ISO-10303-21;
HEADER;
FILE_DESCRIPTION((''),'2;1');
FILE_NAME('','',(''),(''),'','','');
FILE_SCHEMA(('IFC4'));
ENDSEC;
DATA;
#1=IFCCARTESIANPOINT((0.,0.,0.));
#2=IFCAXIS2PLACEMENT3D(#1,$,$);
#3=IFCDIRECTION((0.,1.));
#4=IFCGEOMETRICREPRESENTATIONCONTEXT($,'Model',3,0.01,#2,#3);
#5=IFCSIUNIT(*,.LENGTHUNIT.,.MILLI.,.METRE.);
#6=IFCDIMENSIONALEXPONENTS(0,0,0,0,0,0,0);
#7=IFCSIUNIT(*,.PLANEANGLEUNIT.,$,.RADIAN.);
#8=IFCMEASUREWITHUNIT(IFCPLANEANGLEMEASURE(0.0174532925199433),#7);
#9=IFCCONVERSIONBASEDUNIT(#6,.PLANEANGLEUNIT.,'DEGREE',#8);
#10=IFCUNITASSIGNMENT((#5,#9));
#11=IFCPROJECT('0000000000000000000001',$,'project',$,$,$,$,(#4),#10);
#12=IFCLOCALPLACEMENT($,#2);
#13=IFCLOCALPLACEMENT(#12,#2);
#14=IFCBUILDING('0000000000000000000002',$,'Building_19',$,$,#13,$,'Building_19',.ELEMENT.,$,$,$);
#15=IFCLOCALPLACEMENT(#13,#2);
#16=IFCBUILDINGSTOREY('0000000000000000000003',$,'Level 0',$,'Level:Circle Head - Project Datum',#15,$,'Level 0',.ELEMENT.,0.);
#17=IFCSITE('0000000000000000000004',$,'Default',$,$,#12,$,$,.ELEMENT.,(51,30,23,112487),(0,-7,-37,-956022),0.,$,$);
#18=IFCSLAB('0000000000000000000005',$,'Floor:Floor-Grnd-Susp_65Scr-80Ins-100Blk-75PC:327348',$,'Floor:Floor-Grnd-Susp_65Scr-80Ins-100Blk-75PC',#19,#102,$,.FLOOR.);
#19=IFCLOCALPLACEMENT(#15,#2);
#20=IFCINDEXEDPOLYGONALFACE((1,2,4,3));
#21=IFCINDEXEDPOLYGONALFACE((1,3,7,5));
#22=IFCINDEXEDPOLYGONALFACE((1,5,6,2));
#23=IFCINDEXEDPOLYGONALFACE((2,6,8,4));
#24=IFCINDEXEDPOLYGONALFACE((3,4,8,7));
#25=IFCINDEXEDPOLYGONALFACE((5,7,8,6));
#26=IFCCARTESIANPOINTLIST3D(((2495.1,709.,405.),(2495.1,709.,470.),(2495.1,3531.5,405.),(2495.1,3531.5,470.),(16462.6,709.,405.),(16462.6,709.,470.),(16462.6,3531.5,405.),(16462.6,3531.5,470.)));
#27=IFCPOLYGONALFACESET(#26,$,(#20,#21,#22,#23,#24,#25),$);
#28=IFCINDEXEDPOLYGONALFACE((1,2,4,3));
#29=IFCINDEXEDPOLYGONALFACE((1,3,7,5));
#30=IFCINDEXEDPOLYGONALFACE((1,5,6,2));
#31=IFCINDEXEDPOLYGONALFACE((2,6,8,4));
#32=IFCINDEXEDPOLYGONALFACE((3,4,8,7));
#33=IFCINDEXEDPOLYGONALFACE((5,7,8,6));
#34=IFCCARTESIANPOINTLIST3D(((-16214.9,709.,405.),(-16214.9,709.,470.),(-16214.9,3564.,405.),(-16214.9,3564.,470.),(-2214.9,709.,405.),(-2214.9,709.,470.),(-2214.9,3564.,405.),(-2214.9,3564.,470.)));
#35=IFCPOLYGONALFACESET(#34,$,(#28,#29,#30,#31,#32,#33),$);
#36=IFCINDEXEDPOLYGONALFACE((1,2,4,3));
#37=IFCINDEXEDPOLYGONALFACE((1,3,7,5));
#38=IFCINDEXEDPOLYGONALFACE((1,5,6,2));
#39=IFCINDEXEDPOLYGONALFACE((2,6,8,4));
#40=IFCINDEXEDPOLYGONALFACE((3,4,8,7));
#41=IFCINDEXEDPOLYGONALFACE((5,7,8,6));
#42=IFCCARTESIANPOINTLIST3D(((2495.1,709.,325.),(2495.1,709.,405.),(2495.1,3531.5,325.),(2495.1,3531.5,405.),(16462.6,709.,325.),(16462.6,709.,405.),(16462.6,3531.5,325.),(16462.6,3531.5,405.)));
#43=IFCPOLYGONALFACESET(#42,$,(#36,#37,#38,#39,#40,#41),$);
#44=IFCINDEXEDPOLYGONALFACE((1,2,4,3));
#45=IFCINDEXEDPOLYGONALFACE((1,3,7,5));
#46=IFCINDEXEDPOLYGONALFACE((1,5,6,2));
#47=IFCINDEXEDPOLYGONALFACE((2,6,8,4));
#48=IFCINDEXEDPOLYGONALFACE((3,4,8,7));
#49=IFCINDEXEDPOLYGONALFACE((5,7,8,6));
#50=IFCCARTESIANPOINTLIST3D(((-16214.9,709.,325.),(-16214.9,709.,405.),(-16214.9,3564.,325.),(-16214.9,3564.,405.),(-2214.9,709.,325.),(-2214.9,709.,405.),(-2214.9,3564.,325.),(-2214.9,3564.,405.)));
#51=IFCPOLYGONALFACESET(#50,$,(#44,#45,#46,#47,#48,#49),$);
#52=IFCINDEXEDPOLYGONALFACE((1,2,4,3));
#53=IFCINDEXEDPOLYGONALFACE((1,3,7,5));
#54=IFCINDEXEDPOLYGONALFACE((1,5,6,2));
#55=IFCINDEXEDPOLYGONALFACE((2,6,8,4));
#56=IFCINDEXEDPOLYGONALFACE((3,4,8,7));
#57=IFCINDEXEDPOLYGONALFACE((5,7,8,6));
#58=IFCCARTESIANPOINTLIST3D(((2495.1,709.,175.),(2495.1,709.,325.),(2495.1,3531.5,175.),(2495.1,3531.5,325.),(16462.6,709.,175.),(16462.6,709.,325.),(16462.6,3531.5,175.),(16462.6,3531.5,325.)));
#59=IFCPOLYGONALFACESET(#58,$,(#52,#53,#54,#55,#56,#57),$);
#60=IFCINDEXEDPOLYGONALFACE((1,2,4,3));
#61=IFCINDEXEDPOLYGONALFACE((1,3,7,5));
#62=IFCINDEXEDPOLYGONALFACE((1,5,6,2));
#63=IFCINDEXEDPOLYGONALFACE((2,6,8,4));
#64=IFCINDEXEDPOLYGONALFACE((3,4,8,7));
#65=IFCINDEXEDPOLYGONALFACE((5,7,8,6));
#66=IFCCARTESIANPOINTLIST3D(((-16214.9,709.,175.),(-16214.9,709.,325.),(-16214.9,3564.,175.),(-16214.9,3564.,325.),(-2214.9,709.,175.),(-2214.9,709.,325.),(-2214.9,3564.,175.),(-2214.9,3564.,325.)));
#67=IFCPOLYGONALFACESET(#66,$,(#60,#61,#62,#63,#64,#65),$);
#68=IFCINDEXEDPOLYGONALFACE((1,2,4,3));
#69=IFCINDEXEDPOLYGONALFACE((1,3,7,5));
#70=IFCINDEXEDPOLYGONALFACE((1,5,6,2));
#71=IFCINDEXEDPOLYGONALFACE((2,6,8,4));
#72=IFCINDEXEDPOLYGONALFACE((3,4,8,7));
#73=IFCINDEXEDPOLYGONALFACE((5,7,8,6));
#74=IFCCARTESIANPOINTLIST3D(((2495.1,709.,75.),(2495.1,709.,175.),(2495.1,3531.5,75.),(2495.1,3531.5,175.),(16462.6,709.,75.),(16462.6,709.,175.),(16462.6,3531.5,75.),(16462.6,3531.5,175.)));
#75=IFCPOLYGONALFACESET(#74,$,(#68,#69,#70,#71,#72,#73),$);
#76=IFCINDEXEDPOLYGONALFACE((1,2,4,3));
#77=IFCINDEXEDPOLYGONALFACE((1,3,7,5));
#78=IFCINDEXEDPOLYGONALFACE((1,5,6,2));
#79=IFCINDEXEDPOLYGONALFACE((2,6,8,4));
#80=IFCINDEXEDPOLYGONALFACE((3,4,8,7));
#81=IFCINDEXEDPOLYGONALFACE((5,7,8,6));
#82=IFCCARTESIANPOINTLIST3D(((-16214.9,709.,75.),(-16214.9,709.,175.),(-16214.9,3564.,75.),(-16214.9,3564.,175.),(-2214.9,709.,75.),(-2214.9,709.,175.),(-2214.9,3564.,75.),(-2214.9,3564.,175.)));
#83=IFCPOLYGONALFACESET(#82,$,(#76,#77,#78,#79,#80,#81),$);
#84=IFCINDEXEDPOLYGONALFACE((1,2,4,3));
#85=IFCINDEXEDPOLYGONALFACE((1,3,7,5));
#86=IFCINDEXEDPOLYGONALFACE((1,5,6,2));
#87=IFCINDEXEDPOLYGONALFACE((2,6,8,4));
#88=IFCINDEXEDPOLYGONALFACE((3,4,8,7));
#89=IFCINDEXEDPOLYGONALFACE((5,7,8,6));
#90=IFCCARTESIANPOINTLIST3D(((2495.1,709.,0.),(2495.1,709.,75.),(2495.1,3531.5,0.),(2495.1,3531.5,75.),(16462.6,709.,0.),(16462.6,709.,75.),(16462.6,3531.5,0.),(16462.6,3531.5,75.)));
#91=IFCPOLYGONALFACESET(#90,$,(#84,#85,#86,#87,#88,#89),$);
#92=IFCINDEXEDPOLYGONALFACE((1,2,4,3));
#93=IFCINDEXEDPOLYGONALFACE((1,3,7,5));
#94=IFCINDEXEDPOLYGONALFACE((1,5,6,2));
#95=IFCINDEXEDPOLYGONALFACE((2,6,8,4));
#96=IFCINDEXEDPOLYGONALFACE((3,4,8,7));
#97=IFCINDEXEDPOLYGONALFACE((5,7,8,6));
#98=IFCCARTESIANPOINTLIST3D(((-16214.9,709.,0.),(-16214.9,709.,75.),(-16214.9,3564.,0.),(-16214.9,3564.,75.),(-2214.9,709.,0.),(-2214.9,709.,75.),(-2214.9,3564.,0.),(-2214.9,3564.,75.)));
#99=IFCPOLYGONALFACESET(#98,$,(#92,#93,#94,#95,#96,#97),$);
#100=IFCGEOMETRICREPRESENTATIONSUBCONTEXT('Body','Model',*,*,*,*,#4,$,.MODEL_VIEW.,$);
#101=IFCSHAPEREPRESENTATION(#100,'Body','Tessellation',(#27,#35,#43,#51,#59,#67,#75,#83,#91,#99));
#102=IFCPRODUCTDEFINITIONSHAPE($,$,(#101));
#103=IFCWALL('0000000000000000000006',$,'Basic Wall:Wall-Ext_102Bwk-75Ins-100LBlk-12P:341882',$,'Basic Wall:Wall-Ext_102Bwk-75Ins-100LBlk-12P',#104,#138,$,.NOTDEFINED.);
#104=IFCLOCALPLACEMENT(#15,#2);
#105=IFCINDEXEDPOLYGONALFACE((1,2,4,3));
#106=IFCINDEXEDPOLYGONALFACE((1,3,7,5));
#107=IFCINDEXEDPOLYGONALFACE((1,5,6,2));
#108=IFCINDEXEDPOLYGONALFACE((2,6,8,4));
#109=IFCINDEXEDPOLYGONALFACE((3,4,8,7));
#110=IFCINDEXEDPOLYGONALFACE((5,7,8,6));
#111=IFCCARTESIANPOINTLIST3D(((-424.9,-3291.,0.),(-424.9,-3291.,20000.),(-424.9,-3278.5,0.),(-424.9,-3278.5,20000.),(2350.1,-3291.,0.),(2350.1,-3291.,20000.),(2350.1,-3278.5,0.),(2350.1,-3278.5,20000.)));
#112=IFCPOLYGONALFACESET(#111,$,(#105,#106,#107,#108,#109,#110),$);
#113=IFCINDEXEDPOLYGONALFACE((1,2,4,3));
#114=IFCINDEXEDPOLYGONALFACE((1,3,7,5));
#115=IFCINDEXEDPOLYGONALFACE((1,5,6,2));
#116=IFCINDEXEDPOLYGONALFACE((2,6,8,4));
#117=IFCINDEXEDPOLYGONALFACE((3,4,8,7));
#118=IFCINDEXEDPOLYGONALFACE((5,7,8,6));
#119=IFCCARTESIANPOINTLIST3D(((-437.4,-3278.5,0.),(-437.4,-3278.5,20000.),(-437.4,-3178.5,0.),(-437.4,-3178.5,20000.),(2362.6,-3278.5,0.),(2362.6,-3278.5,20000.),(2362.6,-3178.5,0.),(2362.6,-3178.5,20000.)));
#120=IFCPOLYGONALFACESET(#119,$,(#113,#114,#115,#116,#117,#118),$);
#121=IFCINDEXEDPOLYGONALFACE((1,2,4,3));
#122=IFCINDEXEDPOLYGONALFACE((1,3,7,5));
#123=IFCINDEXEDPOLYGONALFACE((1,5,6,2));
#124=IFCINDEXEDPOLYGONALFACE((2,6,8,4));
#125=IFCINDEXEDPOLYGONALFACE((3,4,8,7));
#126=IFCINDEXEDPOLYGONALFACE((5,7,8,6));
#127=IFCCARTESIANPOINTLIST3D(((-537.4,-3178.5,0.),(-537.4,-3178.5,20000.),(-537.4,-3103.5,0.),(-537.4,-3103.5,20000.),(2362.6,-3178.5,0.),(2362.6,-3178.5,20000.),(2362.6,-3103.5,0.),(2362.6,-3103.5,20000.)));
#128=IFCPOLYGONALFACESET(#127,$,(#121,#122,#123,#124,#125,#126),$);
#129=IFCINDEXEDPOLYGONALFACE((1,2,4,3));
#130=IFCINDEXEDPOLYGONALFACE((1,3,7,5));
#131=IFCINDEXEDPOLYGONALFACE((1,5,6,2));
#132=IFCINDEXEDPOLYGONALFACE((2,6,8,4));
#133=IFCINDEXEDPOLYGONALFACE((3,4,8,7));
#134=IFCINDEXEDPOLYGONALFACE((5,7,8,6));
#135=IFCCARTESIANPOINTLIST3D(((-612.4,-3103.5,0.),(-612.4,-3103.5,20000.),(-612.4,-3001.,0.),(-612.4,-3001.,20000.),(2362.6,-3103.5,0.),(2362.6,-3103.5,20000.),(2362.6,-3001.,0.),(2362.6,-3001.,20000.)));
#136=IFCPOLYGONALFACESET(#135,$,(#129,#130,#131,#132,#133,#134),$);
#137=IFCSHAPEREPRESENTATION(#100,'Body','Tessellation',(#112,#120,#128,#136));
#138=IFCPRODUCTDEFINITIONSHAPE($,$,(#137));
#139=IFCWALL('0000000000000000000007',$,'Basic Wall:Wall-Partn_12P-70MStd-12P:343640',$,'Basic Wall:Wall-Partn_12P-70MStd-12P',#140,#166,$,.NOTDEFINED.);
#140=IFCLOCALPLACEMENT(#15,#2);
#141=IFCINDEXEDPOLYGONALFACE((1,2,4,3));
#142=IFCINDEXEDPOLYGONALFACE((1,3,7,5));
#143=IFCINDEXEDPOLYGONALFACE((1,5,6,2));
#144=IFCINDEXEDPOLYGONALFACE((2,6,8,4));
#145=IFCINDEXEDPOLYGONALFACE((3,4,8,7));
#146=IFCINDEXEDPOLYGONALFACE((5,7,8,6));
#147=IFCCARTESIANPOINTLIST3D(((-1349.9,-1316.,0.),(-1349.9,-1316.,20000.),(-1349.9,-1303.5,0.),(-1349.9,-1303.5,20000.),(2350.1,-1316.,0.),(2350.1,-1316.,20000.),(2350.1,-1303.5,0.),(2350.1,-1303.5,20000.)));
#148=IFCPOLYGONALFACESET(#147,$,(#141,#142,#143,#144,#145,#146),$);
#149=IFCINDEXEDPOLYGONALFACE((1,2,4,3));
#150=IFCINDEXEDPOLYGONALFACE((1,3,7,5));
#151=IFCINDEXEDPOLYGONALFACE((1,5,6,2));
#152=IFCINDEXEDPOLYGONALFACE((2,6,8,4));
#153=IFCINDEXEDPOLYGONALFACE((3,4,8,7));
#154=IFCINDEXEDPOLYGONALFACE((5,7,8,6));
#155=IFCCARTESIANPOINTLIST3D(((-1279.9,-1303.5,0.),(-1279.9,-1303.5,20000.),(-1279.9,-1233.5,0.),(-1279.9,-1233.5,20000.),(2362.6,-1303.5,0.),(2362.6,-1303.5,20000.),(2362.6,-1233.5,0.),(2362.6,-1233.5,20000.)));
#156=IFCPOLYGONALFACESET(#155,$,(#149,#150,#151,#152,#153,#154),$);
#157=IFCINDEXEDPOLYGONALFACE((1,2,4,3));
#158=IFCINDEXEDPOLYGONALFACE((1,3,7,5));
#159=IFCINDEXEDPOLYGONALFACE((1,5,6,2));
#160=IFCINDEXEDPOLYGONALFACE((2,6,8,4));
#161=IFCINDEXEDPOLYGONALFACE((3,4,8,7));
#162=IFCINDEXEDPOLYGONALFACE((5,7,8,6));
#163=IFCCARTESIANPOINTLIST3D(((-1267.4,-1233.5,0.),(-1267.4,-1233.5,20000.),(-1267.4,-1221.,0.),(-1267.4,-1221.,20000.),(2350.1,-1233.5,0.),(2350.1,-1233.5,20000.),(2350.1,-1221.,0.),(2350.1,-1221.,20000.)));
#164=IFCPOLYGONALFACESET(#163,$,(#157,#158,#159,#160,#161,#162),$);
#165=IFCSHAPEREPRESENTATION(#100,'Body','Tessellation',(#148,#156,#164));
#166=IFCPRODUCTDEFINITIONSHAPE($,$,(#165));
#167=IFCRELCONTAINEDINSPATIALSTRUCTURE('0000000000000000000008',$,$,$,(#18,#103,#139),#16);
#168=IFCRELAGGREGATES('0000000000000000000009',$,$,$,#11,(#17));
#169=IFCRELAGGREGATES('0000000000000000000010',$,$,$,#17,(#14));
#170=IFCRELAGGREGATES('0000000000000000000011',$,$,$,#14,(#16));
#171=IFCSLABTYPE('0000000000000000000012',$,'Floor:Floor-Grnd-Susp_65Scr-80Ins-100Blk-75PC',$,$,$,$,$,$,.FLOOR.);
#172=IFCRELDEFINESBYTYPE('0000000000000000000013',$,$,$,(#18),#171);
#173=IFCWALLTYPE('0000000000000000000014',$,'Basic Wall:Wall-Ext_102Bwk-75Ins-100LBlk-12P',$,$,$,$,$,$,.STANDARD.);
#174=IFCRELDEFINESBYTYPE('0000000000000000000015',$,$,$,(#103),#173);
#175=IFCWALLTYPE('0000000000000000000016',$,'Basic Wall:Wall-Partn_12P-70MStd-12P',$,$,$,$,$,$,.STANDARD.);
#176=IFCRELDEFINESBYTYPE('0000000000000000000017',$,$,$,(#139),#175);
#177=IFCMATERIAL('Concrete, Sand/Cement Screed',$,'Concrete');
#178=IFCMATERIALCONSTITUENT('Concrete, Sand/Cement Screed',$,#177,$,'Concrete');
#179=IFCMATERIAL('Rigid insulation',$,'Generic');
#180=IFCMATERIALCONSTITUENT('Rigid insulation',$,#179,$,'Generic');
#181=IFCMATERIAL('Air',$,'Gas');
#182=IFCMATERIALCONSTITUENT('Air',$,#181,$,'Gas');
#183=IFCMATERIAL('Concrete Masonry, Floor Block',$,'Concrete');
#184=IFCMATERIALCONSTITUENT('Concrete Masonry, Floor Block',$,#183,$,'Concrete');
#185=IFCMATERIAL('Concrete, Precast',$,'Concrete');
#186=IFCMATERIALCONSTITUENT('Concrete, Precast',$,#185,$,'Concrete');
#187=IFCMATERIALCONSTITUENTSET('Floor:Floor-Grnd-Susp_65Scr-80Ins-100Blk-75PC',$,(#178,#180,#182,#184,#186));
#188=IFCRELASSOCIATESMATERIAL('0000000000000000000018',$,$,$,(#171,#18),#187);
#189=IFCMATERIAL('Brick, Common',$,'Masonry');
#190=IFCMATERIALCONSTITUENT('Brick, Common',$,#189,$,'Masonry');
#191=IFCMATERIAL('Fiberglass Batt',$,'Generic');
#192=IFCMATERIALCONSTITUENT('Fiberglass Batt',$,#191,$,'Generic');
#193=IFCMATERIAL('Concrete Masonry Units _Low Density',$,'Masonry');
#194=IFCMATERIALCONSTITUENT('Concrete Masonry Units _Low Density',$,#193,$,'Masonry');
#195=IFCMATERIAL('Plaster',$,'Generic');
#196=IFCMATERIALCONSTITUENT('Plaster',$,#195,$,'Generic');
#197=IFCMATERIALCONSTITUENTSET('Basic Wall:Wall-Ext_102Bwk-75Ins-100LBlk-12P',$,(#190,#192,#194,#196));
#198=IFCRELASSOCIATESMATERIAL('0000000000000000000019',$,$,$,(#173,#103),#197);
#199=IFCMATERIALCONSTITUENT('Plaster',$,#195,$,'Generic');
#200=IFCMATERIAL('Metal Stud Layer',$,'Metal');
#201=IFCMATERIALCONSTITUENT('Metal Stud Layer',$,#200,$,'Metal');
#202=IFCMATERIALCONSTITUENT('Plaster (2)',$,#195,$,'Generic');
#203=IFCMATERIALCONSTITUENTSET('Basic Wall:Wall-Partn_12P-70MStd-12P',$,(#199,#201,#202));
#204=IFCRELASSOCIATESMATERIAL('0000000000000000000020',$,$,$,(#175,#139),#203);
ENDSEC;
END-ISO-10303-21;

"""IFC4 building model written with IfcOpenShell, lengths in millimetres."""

from ifc_helpers import new_model, entity, si_unit, converted_unit, direction, frame, origin, place, context, subcontext, project, spatial, indexed_curve, outline, extrude, material, constituent, constituent_set, type_object, element, save


model = new_model("IFC4")

# Units and contexts
model_context = context("Model", 3, precision=0.01, world=origin(), true_north=direction((0.0, 1.0)))
body_context = subcontext(model_context, "Body", "Model", "MODEL_VIEW")
ifc_project = project(units=[si_unit("LENGTHUNIT", "METRE", prefix="MILLI"), converted_unit("PLANEANGLEUNIT", "DEGREE", entity("IfcPlaneAngleMeasure", 0.0174532925199433), si_unit("PLANEANGLEUNIT", "RADIAN"), dimensions=[0, 0, 0, 0, 0, 0, 0])], contexts=[model_context])

# Site, building, storey
site_placement = place(None, origin())
site = spatial("IfcSite", under=ifc_project, at=site_placement, Name="Default", CompositionType="ELEMENT", RefLatitude=(51, 30, 23, 112487), RefLongitude=(0, -7, -37, -956022), RefElevation=0.0)
building_placement = place(site_placement, origin())
building = spatial("IfcBuilding", under=site, at=building_placement, Name="Building_19", LongName="Building_19", CompositionType="ELEMENT")
storey_placement = place(building_placement, origin())
storey = spatial("IfcBuildingStorey", under=building, at=storey_placement, Name="Level 0", ObjectType="Level:Circle Head - Project Datum", LongName="Level 0", CompositionType="ELEMENT", Elevation=0.0)

# Slab
ifc_material_1 = material(Name="Concrete, Sand/Cement Screed", Category="Concrete")
ifc_constituent_1 = constituent(ifc_material_1, Name="Concrete, Sand/Cement Screed", Category="Concrete")
ifc_material_2 = material(Name="Rigid insulation", Category="Generic")
ifc_constituent_2 = constituent(ifc_material_2, Name="Rigid insulation", Category="Generic")
ifc_material_3 = material(Name="Air", Category="Gas")
ifc_constituent_3 = constituent(ifc_material_3, Name="Air", Category="Gas")
ifc_material_4 = material(Name="Concrete Masonry, Floor Block", Category="Concrete")
ifc_constituent_4 = constituent(ifc_material_4, Name="Concrete Masonry, Floor Block", Category="Concrete")
ifc_material_5 = material(Name="Concrete, Precast", Category="Concrete")
ifc_constituent_5 = constituent(ifc_material_5, Name="Concrete, Precast", Category="Concrete")
ifc_constituent_set_1 = constituent_set(constituents=[ifc_constituent_1, ifc_constituent_2, ifc_constituent_3, ifc_constituent_4, ifc_constituent_5], Name="Floor:Floor-Grnd-Susp_65Scr-80Ins-100Blk-75PC")
slab_type = type_object("IfcSlabType", Name="Floor:Floor-Grnd-Susp_65Scr-80Ins-100Blk-75PC", PredefinedType="FLOOR", material=ifc_constituent_set_1)
slab_1_placement = place(storey_placement, origin())
element("IfcSlab", 1, at=slab_1_placement, inside=storey, type_object=slab_type, material=ifc_constituent_set_1, Name="Floor:Floor-Grnd-Susp_65Scr-80Ins-100Blk-75PC:327348", ObjectType="Floor:Floor-Grnd-Susp_65Scr-80Ins-100Blk-75PC", PredefinedType="FLOOR", context=body_context, shape_type="SweptSolid", body=[
    extrude(outline(indexed_curve([(-6983.8, -1411.3), (6983.8, -1411.3), (6983.8, 1411.3), (-6983.8, 1411.3), (-6983.8, -1411.3)], self_intersect=False)), frame((9478.8, 2120.2, 405.0), z_axis=(0.0, 0.0, 1.0), x_axis=(-1.0, 0.0, 0.0)), (0.0, 0.0, 1.0), 65.0),
    extrude(outline(indexed_curve([(-1427.5, -7000.0), (1427.5, -7000.0), (1427.5, 7000.0), (-1427.5, 7000.0), (-1427.5, -7000.0)], self_intersect=False)), frame((-9214.9, 2136.5, 405.0), z_axis=(0.0, 0.0, 1.0), x_axis=(0.0, 1.0, 0.0)), (0.0, 0.0, 1.0), 65.0),
    extrude(outline(indexed_curve([(-6983.8, -1411.3), (6983.8, -1411.3), (6983.8, 1411.3), (-6983.8, 1411.3), (-6983.8, -1411.3)], self_intersect=False)), frame((9478.8, 2120.2, 325.0), z_axis=(0.0, 0.0, 1.0), x_axis=(-1.0, 0.0, 0.0)), (0.0, 0.0, 1.0), 80.0),
    extrude(outline(indexed_curve([(-1427.5, -7000.0), (1427.5, -7000.0), (1427.5, 7000.0), (-1427.5, 7000.0), (-1427.5, -7000.0)], self_intersect=False)), frame((-9214.9, 2136.5, 325.0), z_axis=(0.0, 0.0, 1.0), x_axis=(0.0, 1.0, 0.0)), (0.0, 0.0, 1.0), 80.0),
    extrude(outline(indexed_curve([(-6983.8, -1411.3), (6983.8, -1411.3), (6983.8, 1411.3), (-6983.8, 1411.3), (-6983.8, -1411.3)], self_intersect=False)), frame((9478.8, 2120.2, 175.0), z_axis=(0.0, 0.0, 1.0), x_axis=(-1.0, 0.0, 0.0)), (0.0, 0.0, 1.0), 150.0),
    extrude(outline(indexed_curve([(-1427.5, -7000.0), (1427.5, -7000.0), (1427.5, 7000.0), (-1427.5, 7000.0), (-1427.5, -7000.0)], self_intersect=False)), frame((-9214.9, 2136.5, 175.0), z_axis=(0.0, 0.0, 1.0), x_axis=(0.0, 1.0, 0.0)), (0.0, 0.0, 1.0), 150.0),
    extrude(outline(indexed_curve([(-6983.8, -1411.3), (6983.8, -1411.3), (6983.8, 1411.3), (-6983.8, 1411.3), (-6983.8, -1411.3)], self_intersect=False)), frame((9478.8, 2120.2, 75.0), z_axis=(0.0, 0.0, 1.0), x_axis=(-1.0, 0.0, 0.0)), (0.0, 0.0, 1.0), 100.0),
    extrude(outline(indexed_curve([(-1427.5, -7000.0), (1427.5, -7000.0), (1427.5, 7000.0), (-1427.5, 7000.0), (-1427.5, -7000.0)], self_intersect=False)), frame((-9214.9, 2136.5, 75.0), z_axis=(0.0, 0.0, 1.0), x_axis=(0.0, 1.0, 0.0)), (0.0, 0.0, 1.0), 100.0),
    extrude(outline(indexed_curve([(-6983.8, -1411.3), (6983.8, -1411.3), (6983.8, 1411.3), (-6983.8, 1411.3), (-6983.8, -1411.3)], self_intersect=False)), frame((9478.8, 2120.2, 0.0), z_axis=(0.0, 0.0, 1.0), x_axis=(-1.0, 0.0, 0.0)), (0.0, 0.0, 1.0), 75.0),
    extrude(outline(indexed_curve([(-1427.5, -7000.0), (1427.5, -7000.0), (1427.5, 7000.0), (-1427.5, 7000.0), (-1427.5, -7000.0)], self_intersect=False)), frame((-9214.9, 2136.5, 0.0), z_axis=(0.0, 0.0, 1.0), x_axis=(0.0, 1.0, 0.0)), (0.0, 0.0, 1.0), 75.0),
])

# Shared definitions
ifc_material_6 = material(Name="Brick, Common", Category="Masonry")
ifc_constituent_6 = constituent(ifc_material_6, Name="Brick, Common", Category="Masonry")
ifc_material_7 = material(Name="Fiberglass Batt", Category="Generic")
ifc_constituent_7 = constituent(ifc_material_7, Name="Fiberglass Batt", Category="Generic")
ifc_material_8 = material(Name="Concrete Masonry Units _Low Density", Category="Masonry")
ifc_constituent_8 = constituent(ifc_material_8, Name="Concrete Masonry Units _Low Density", Category="Masonry")
ifc_material_9 = material(Name="Plaster", Category="Generic")
ifc_constituent_9 = constituent(ifc_material_9, Name="Plaster", Category="Generic")
ifc_constituent_set_2 = constituent_set(constituents=[ifc_constituent_6, ifc_constituent_7, ifc_constituent_8, ifc_constituent_9], Name="Basic Wall:Wall-Ext_102Bwk-75Ins-100LBlk-12P")
wall_type_1 = type_object("IfcWallType", Name="Basic Wall:Wall-Ext_102Bwk-75Ins-100LBlk-12P", PredefinedType="STANDARD", material=ifc_constituent_set_2)

# Wall
wall_1_placement = place(storey_placement, frame((-424.9, -3146.0, 0.0)))
element("IfcWall", 2, at=wall_1_placement, inside=storey, type_object=wall_type_1, material=ifc_constituent_set_2, Name="Basic Wall:Wall-Ext_102Bwk-75Ins-100LBlk-12P:341882", ObjectType="Basic Wall:Wall-Ext_102Bwk-75Ins-100LBlk-12P", PredefinedType="NOTDEFINED", context=body_context, shape_type="SweptSolid", body=[
    extrude(outline(indexed_curve([(-6.3, -1387.5), (6.2, -1387.5), (6.3, 1387.5), (-6.2, 1387.5), (-6.3, -1387.5)], self_intersect=False)), frame((1387.5, -138.8, 0.0), z_axis=(0.0, 0.0, 1.0), x_axis=(0.0, 1.0, 0.0)), (0.0, 0.0, 1.0), 20000.0),
    extrude(outline(indexed_curve([(-1400.0, -50.0), (1400.0, -50.0), (1400.0, 50.0), (-1400.0, 50.0), (-1400.0, -50.0)], self_intersect=False)), frame((1387.5, -82.5, 0.0)), (0.0, 0.0, 1.0), 20000.0),
    extrude(outline(indexed_curve([(-1450.0, -37.5), (1450.0, -37.5), (1450.0, 37.5), (-1450.0, 37.5), (-1450.0, -37.5)], self_intersect=False)), frame((1337.5, 5.0, 0.0)), (0.0, 0.0, 1.0), 20000.0),
    extrude(outline(indexed_curve([(-51.3, -1487.5), (51.2, -1487.5), (51.3, 1487.5), (-51.2, 1487.5), (-51.3, -1487.5)], self_intersect=False)), frame((1300.0, 93.7, 0.0), z_axis=(0.0, 0.0, 1.0), x_axis=(0.0, -1.0, 0.0)), (0.0, 0.0, 1.0), 20000.0),
])

# Shared definitions
ifc_constituent_10 = constituent(ifc_material_9, Name="Plaster", Category="Generic")
ifc_material_10 = material(Name="Metal Stud Layer", Category="Metal")
ifc_constituent_11 = constituent(ifc_material_10, Name="Metal Stud Layer", Category="Metal")
ifc_constituent_12 = constituent(ifc_material_9, Name="Plaster (2)", Category="Generic")
ifc_constituent_set_3 = constituent_set(constituents=[ifc_constituent_10, ifc_constituent_11, ifc_constituent_12], Name="Basic Wall:Wall-Partn_12P-70MStd-12P")
wall_type_2 = type_object("IfcWallType", Name="Basic Wall:Wall-Partn_12P-70MStd-12P", PredefinedType="STANDARD", material=ifc_constituent_set_3)

# Wall
wall_2_placement = place(storey_placement, frame((-1267.4, -1268.5, 0.0)))
element("IfcWall", 3, at=wall_2_placement, inside=storey, type_object=wall_type_2, material=ifc_constituent_set_3, Name="Basic Wall:Wall-Partn_12P-70MStd-12P:343640", ObjectType="Basic Wall:Wall-Partn_12P-70MStd-12P", PredefinedType="NOTDEFINED", context=body_context, shape_type="SweptSolid", body=[
    extrude(outline(indexed_curve([(-6.3, -1850.0), (6.2, -1850.0), (6.3, 1850.0), (-6.2, 1850.0), (-6.3, -1850.0)], self_intersect=False)), frame((1767.5, -41.2, 0.0), z_axis=(0.0, 0.0, 1.0), x_axis=(0.0, 1.0, 0.0)), (0.0, 0.0, 1.0), 20000.0),
    extrude(outline(indexed_curve([(-1821.2, -35.0), (1821.2, -35.0), (1821.2, 35.0), (-1821.2, 35.0), (-1821.2, -35.0)], self_intersect=False)), frame((1808.8, 0.0, 0.0)), (0.0, 0.0, 1.0), 20000.0),
    extrude(outline(indexed_curve([(-6.3, -1808.8), (6.2, -1808.8), (6.3, 1808.8), (-6.2, 1808.8), (-6.3, -1808.8)], self_intersect=False)), frame((1808.8, 41.3, 0.0), z_axis=(0.0, 0.0, 1.0), x_axis=(0.0, -1.0, 0.0)), (0.0, 0.0, 1.0), 20000.0),
])

save(model, "model.ifc")
